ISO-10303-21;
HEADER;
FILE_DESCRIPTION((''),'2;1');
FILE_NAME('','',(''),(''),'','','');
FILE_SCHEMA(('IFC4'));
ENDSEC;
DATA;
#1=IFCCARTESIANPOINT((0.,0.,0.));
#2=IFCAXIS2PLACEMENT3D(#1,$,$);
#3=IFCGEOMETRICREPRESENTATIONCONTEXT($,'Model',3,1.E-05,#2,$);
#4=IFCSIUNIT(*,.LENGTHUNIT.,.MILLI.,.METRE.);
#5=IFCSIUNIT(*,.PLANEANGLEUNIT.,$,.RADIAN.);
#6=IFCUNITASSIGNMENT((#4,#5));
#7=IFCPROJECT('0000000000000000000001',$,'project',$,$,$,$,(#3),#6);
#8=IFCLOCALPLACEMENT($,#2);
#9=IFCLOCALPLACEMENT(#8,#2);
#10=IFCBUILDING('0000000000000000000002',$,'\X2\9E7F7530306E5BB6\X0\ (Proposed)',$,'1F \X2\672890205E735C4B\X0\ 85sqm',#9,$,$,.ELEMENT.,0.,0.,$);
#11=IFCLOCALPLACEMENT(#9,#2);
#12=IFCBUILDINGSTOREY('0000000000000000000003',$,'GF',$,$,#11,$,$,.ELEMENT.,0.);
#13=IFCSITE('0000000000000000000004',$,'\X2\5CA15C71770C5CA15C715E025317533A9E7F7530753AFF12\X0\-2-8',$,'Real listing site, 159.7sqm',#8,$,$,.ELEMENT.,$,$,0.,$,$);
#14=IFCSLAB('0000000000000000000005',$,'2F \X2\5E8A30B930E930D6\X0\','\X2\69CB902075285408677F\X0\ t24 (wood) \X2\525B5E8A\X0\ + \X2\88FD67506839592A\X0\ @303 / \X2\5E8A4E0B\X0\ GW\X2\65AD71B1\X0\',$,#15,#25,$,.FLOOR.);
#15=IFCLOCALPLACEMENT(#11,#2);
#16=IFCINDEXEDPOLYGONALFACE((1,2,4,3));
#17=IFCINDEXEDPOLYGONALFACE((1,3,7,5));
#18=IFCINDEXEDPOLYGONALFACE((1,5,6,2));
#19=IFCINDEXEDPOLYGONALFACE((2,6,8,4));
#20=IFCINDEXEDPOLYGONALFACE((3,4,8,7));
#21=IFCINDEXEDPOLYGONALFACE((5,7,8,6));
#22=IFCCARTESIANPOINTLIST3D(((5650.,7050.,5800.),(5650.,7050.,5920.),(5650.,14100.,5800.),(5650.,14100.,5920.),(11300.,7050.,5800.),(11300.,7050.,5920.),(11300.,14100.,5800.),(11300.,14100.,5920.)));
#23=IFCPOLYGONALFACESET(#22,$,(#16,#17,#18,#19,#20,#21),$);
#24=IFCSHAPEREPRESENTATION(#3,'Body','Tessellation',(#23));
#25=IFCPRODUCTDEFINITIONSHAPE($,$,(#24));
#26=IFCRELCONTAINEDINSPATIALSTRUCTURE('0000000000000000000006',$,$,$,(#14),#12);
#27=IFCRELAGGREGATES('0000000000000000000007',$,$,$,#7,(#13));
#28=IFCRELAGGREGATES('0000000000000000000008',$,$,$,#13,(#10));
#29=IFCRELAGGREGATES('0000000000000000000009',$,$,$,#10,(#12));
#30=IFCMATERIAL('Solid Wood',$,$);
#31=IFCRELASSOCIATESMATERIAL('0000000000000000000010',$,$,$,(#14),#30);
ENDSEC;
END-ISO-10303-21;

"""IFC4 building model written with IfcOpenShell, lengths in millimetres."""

from ifc_helpers import new_model, si_unit, frame, frame_2d, origin, place, context, project, spatial, rectangle, extrude, material, element, save


model = new_model("IFC4")

# Units and contexts
model_context = context("Model", 3, precision=1e-05, world=origin())
ifc_project = project(units=[si_unit("LENGTHUNIT", "METRE", prefix="MILLI"), si_unit("PLANEANGLEUNIT", "RADIAN")], contexts=[model_context])

# Site, building, storey
site_placement = place(None, origin())
site = spatial("IfcSite", under=ifc_project, at=site_placement, Name="岡山県岡山市北区鹿田町２-2-8", ObjectType="Real listing site, 159.7sqm", CompositionType="ELEMENT", RefElevation=0.0)
building_placement = place(site_placement, origin())
building = spatial("IfcBuilding", under=site, at=building_placement, Name="鹿田の家 (Proposed)", ObjectType="1F 木造平屋 85sqm", CompositionType="ELEMENT", ElevationOfRefHeight=0.0, ElevationOfTerrain=0.0)
storey_placement = place(building_placement, origin())
storey = spatial("IfcBuildingStorey", under=building, at=storey_placement, Name="GF", CompositionType="ELEMENT", Elevation=0.0)

# Slab
ifc_material_1 = material(Name="Solid Wood")
slab_placement = place(storey_placement, frame((2825.0, 3525.0, 2900.0)))
element("IfcSlab", 1, at=slab_placement, inside=storey, material=ifc_material_1, Name="2F 床スラブ", Description="構造用合板 t24 (wood) 剛床 + 製材根太 @303 / 床下 GW断熱", PredefinedType="FLOOR", context=model_context, shape_type="SweptSolid", body=[
    extrude(rectangle(XDim=5650.0, YDim=7050.0, at=frame_2d((2825.0, 3525.0))), frame((2825.0, 3525.0, 2900.0)), (0.0, 0.0, 1.0), 120.0),
])

save(model, "model.ifc")
